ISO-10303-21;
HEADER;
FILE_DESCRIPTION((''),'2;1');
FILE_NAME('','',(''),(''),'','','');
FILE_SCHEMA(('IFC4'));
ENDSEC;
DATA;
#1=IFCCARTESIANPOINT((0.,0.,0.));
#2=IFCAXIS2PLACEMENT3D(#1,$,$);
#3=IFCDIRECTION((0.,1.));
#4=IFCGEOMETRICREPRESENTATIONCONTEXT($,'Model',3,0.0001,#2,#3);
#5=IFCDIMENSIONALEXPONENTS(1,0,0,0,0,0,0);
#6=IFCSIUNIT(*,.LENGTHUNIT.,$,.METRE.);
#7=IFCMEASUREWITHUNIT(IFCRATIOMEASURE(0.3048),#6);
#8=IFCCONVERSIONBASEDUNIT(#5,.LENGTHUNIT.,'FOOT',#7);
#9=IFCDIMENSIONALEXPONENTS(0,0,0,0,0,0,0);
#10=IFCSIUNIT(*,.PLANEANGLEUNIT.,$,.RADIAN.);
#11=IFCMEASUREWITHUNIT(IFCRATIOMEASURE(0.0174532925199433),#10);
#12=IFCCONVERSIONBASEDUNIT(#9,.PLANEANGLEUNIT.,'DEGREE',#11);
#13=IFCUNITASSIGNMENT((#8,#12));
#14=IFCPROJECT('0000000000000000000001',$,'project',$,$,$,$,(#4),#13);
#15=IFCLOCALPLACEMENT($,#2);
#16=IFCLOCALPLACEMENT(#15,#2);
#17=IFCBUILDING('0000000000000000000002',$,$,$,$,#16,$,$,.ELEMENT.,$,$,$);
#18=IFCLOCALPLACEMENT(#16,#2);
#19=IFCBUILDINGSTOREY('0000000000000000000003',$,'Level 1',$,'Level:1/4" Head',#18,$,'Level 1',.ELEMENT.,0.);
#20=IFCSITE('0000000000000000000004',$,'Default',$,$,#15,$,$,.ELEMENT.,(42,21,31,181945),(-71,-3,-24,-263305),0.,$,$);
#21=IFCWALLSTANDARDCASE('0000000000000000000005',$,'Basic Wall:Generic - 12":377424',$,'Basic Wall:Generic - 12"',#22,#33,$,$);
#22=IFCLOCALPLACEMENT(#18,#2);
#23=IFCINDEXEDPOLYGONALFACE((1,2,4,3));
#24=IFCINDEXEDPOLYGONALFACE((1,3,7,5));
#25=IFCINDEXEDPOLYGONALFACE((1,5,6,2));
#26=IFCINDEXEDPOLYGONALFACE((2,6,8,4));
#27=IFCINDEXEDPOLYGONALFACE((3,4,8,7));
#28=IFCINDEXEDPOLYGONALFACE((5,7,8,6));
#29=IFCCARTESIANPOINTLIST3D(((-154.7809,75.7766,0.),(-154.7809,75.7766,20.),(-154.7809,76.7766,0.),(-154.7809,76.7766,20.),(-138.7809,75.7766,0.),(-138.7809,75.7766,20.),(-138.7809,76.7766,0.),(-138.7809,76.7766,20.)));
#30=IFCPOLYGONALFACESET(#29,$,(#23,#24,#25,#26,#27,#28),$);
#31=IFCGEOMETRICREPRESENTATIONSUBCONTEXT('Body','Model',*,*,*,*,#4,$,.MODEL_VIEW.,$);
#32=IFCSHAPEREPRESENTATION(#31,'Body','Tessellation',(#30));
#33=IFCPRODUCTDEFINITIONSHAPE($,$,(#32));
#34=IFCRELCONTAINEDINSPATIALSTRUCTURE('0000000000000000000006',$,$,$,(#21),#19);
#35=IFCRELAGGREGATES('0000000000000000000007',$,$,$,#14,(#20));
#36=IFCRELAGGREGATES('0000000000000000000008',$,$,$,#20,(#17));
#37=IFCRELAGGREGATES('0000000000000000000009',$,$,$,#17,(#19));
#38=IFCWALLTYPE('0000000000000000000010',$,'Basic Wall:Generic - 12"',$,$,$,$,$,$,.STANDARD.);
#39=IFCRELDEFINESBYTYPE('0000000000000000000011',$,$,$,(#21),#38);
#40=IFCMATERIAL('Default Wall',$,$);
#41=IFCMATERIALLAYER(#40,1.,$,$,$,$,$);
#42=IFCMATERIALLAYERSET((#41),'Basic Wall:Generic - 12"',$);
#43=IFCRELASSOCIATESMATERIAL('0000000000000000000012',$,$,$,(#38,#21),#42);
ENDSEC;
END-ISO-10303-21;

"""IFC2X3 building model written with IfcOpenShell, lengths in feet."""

from ifc_helpers import new_model, entity, si_unit, converted_unit, direction, frame, frame_2d, origin, place, context, subcontext, project, spatial, rectangle, extrude, material, layer, layer_set, layer_usage, type_object, element, save


model = new_model("IFC2X3")

# Units and contexts
model_context = context("Model", 3, precision=0.0001, world=origin(), true_north=direction((0.0, 1.0)))
body_context = subcontext(model_context, "Body", "Model", "MODEL_VIEW")
ifc_project = project(units=[converted_unit("LENGTHUNIT", "FOOT", entity("IfcRatioMeasure", 0.3048), si_unit("LENGTHUNIT", "METRE"), dimensions=[1, 0, 0, 0, 0, 0, 0]), converted_unit("PLANEANGLEUNIT", "DEGREE", entity("IfcRatioMeasure", 0.0174532925199433), si_unit("PLANEANGLEUNIT", "RADIAN"), dimensions=[0, 0, 0, 0, 0, 0, 0])], contexts=[model_context])

# Site, building, storey
site_placement = place(None, origin())
site = spatial("IfcSite", under=ifc_project, at=site_placement, Name="Default", CompositionType="ELEMENT", RefLatitude=(42, 21, 31, 181945), RefLongitude=(-71, -3, -24, -263305), RefElevation=0.0)
building_placement = place(site_placement, origin())
building = spatial("IfcBuilding", under=site, at=building_placement, CompositionType="ELEMENT")
storey_placement = place(building_placement, origin())
storey = spatial("IfcBuildingStorey", under=building, at=storey_placement, Name="Level 1", ObjectType="Level:1/4\" Head", LongName="Level 1", CompositionType="ELEMENT", Elevation=0.0)

# Shared definitions
ifc_material = material(Name="Default Wall")

# Wall
ifc_layer_1 = layer(ifc_material, 1.0)
ifc_layer_set_1 = layer_set([ifc_layer_1], Name="Basic Wall:Generic - 12\"")
ifc_layer_usage_1 = layer_usage(ifc_layer_set_1, "AXIS2", "NEGATIVE", 0.5)
wall_type_1 = type_object("IfcWallType", Name="Basic Wall:Generic - 12\"", PredefinedType="STANDARD", material=ifc_layer_set_1)
wall_1_placement = place(storey_placement, frame((-154.7809, 76.2766, 0.0)))
element("IfcWallStandardCase", 1, at=wall_1_placement, inside=storey, type_object=wall_type_1, material=ifc_layer_usage_1, Name="Basic Wall:Generic - 12\":377424", ObjectType="Basic Wall:Generic - 12\"", context=body_context, shape_type="SweptSolid", body=[
    extrude(rectangle(XDim=16.0, YDim=1.0, at=frame_2d((8.0, 0.0), x_axis=(-1.0, 0.0))), origin(), (0.0, 0.0, 1.0), 20.0),
])

save(model, "model.ifc")
